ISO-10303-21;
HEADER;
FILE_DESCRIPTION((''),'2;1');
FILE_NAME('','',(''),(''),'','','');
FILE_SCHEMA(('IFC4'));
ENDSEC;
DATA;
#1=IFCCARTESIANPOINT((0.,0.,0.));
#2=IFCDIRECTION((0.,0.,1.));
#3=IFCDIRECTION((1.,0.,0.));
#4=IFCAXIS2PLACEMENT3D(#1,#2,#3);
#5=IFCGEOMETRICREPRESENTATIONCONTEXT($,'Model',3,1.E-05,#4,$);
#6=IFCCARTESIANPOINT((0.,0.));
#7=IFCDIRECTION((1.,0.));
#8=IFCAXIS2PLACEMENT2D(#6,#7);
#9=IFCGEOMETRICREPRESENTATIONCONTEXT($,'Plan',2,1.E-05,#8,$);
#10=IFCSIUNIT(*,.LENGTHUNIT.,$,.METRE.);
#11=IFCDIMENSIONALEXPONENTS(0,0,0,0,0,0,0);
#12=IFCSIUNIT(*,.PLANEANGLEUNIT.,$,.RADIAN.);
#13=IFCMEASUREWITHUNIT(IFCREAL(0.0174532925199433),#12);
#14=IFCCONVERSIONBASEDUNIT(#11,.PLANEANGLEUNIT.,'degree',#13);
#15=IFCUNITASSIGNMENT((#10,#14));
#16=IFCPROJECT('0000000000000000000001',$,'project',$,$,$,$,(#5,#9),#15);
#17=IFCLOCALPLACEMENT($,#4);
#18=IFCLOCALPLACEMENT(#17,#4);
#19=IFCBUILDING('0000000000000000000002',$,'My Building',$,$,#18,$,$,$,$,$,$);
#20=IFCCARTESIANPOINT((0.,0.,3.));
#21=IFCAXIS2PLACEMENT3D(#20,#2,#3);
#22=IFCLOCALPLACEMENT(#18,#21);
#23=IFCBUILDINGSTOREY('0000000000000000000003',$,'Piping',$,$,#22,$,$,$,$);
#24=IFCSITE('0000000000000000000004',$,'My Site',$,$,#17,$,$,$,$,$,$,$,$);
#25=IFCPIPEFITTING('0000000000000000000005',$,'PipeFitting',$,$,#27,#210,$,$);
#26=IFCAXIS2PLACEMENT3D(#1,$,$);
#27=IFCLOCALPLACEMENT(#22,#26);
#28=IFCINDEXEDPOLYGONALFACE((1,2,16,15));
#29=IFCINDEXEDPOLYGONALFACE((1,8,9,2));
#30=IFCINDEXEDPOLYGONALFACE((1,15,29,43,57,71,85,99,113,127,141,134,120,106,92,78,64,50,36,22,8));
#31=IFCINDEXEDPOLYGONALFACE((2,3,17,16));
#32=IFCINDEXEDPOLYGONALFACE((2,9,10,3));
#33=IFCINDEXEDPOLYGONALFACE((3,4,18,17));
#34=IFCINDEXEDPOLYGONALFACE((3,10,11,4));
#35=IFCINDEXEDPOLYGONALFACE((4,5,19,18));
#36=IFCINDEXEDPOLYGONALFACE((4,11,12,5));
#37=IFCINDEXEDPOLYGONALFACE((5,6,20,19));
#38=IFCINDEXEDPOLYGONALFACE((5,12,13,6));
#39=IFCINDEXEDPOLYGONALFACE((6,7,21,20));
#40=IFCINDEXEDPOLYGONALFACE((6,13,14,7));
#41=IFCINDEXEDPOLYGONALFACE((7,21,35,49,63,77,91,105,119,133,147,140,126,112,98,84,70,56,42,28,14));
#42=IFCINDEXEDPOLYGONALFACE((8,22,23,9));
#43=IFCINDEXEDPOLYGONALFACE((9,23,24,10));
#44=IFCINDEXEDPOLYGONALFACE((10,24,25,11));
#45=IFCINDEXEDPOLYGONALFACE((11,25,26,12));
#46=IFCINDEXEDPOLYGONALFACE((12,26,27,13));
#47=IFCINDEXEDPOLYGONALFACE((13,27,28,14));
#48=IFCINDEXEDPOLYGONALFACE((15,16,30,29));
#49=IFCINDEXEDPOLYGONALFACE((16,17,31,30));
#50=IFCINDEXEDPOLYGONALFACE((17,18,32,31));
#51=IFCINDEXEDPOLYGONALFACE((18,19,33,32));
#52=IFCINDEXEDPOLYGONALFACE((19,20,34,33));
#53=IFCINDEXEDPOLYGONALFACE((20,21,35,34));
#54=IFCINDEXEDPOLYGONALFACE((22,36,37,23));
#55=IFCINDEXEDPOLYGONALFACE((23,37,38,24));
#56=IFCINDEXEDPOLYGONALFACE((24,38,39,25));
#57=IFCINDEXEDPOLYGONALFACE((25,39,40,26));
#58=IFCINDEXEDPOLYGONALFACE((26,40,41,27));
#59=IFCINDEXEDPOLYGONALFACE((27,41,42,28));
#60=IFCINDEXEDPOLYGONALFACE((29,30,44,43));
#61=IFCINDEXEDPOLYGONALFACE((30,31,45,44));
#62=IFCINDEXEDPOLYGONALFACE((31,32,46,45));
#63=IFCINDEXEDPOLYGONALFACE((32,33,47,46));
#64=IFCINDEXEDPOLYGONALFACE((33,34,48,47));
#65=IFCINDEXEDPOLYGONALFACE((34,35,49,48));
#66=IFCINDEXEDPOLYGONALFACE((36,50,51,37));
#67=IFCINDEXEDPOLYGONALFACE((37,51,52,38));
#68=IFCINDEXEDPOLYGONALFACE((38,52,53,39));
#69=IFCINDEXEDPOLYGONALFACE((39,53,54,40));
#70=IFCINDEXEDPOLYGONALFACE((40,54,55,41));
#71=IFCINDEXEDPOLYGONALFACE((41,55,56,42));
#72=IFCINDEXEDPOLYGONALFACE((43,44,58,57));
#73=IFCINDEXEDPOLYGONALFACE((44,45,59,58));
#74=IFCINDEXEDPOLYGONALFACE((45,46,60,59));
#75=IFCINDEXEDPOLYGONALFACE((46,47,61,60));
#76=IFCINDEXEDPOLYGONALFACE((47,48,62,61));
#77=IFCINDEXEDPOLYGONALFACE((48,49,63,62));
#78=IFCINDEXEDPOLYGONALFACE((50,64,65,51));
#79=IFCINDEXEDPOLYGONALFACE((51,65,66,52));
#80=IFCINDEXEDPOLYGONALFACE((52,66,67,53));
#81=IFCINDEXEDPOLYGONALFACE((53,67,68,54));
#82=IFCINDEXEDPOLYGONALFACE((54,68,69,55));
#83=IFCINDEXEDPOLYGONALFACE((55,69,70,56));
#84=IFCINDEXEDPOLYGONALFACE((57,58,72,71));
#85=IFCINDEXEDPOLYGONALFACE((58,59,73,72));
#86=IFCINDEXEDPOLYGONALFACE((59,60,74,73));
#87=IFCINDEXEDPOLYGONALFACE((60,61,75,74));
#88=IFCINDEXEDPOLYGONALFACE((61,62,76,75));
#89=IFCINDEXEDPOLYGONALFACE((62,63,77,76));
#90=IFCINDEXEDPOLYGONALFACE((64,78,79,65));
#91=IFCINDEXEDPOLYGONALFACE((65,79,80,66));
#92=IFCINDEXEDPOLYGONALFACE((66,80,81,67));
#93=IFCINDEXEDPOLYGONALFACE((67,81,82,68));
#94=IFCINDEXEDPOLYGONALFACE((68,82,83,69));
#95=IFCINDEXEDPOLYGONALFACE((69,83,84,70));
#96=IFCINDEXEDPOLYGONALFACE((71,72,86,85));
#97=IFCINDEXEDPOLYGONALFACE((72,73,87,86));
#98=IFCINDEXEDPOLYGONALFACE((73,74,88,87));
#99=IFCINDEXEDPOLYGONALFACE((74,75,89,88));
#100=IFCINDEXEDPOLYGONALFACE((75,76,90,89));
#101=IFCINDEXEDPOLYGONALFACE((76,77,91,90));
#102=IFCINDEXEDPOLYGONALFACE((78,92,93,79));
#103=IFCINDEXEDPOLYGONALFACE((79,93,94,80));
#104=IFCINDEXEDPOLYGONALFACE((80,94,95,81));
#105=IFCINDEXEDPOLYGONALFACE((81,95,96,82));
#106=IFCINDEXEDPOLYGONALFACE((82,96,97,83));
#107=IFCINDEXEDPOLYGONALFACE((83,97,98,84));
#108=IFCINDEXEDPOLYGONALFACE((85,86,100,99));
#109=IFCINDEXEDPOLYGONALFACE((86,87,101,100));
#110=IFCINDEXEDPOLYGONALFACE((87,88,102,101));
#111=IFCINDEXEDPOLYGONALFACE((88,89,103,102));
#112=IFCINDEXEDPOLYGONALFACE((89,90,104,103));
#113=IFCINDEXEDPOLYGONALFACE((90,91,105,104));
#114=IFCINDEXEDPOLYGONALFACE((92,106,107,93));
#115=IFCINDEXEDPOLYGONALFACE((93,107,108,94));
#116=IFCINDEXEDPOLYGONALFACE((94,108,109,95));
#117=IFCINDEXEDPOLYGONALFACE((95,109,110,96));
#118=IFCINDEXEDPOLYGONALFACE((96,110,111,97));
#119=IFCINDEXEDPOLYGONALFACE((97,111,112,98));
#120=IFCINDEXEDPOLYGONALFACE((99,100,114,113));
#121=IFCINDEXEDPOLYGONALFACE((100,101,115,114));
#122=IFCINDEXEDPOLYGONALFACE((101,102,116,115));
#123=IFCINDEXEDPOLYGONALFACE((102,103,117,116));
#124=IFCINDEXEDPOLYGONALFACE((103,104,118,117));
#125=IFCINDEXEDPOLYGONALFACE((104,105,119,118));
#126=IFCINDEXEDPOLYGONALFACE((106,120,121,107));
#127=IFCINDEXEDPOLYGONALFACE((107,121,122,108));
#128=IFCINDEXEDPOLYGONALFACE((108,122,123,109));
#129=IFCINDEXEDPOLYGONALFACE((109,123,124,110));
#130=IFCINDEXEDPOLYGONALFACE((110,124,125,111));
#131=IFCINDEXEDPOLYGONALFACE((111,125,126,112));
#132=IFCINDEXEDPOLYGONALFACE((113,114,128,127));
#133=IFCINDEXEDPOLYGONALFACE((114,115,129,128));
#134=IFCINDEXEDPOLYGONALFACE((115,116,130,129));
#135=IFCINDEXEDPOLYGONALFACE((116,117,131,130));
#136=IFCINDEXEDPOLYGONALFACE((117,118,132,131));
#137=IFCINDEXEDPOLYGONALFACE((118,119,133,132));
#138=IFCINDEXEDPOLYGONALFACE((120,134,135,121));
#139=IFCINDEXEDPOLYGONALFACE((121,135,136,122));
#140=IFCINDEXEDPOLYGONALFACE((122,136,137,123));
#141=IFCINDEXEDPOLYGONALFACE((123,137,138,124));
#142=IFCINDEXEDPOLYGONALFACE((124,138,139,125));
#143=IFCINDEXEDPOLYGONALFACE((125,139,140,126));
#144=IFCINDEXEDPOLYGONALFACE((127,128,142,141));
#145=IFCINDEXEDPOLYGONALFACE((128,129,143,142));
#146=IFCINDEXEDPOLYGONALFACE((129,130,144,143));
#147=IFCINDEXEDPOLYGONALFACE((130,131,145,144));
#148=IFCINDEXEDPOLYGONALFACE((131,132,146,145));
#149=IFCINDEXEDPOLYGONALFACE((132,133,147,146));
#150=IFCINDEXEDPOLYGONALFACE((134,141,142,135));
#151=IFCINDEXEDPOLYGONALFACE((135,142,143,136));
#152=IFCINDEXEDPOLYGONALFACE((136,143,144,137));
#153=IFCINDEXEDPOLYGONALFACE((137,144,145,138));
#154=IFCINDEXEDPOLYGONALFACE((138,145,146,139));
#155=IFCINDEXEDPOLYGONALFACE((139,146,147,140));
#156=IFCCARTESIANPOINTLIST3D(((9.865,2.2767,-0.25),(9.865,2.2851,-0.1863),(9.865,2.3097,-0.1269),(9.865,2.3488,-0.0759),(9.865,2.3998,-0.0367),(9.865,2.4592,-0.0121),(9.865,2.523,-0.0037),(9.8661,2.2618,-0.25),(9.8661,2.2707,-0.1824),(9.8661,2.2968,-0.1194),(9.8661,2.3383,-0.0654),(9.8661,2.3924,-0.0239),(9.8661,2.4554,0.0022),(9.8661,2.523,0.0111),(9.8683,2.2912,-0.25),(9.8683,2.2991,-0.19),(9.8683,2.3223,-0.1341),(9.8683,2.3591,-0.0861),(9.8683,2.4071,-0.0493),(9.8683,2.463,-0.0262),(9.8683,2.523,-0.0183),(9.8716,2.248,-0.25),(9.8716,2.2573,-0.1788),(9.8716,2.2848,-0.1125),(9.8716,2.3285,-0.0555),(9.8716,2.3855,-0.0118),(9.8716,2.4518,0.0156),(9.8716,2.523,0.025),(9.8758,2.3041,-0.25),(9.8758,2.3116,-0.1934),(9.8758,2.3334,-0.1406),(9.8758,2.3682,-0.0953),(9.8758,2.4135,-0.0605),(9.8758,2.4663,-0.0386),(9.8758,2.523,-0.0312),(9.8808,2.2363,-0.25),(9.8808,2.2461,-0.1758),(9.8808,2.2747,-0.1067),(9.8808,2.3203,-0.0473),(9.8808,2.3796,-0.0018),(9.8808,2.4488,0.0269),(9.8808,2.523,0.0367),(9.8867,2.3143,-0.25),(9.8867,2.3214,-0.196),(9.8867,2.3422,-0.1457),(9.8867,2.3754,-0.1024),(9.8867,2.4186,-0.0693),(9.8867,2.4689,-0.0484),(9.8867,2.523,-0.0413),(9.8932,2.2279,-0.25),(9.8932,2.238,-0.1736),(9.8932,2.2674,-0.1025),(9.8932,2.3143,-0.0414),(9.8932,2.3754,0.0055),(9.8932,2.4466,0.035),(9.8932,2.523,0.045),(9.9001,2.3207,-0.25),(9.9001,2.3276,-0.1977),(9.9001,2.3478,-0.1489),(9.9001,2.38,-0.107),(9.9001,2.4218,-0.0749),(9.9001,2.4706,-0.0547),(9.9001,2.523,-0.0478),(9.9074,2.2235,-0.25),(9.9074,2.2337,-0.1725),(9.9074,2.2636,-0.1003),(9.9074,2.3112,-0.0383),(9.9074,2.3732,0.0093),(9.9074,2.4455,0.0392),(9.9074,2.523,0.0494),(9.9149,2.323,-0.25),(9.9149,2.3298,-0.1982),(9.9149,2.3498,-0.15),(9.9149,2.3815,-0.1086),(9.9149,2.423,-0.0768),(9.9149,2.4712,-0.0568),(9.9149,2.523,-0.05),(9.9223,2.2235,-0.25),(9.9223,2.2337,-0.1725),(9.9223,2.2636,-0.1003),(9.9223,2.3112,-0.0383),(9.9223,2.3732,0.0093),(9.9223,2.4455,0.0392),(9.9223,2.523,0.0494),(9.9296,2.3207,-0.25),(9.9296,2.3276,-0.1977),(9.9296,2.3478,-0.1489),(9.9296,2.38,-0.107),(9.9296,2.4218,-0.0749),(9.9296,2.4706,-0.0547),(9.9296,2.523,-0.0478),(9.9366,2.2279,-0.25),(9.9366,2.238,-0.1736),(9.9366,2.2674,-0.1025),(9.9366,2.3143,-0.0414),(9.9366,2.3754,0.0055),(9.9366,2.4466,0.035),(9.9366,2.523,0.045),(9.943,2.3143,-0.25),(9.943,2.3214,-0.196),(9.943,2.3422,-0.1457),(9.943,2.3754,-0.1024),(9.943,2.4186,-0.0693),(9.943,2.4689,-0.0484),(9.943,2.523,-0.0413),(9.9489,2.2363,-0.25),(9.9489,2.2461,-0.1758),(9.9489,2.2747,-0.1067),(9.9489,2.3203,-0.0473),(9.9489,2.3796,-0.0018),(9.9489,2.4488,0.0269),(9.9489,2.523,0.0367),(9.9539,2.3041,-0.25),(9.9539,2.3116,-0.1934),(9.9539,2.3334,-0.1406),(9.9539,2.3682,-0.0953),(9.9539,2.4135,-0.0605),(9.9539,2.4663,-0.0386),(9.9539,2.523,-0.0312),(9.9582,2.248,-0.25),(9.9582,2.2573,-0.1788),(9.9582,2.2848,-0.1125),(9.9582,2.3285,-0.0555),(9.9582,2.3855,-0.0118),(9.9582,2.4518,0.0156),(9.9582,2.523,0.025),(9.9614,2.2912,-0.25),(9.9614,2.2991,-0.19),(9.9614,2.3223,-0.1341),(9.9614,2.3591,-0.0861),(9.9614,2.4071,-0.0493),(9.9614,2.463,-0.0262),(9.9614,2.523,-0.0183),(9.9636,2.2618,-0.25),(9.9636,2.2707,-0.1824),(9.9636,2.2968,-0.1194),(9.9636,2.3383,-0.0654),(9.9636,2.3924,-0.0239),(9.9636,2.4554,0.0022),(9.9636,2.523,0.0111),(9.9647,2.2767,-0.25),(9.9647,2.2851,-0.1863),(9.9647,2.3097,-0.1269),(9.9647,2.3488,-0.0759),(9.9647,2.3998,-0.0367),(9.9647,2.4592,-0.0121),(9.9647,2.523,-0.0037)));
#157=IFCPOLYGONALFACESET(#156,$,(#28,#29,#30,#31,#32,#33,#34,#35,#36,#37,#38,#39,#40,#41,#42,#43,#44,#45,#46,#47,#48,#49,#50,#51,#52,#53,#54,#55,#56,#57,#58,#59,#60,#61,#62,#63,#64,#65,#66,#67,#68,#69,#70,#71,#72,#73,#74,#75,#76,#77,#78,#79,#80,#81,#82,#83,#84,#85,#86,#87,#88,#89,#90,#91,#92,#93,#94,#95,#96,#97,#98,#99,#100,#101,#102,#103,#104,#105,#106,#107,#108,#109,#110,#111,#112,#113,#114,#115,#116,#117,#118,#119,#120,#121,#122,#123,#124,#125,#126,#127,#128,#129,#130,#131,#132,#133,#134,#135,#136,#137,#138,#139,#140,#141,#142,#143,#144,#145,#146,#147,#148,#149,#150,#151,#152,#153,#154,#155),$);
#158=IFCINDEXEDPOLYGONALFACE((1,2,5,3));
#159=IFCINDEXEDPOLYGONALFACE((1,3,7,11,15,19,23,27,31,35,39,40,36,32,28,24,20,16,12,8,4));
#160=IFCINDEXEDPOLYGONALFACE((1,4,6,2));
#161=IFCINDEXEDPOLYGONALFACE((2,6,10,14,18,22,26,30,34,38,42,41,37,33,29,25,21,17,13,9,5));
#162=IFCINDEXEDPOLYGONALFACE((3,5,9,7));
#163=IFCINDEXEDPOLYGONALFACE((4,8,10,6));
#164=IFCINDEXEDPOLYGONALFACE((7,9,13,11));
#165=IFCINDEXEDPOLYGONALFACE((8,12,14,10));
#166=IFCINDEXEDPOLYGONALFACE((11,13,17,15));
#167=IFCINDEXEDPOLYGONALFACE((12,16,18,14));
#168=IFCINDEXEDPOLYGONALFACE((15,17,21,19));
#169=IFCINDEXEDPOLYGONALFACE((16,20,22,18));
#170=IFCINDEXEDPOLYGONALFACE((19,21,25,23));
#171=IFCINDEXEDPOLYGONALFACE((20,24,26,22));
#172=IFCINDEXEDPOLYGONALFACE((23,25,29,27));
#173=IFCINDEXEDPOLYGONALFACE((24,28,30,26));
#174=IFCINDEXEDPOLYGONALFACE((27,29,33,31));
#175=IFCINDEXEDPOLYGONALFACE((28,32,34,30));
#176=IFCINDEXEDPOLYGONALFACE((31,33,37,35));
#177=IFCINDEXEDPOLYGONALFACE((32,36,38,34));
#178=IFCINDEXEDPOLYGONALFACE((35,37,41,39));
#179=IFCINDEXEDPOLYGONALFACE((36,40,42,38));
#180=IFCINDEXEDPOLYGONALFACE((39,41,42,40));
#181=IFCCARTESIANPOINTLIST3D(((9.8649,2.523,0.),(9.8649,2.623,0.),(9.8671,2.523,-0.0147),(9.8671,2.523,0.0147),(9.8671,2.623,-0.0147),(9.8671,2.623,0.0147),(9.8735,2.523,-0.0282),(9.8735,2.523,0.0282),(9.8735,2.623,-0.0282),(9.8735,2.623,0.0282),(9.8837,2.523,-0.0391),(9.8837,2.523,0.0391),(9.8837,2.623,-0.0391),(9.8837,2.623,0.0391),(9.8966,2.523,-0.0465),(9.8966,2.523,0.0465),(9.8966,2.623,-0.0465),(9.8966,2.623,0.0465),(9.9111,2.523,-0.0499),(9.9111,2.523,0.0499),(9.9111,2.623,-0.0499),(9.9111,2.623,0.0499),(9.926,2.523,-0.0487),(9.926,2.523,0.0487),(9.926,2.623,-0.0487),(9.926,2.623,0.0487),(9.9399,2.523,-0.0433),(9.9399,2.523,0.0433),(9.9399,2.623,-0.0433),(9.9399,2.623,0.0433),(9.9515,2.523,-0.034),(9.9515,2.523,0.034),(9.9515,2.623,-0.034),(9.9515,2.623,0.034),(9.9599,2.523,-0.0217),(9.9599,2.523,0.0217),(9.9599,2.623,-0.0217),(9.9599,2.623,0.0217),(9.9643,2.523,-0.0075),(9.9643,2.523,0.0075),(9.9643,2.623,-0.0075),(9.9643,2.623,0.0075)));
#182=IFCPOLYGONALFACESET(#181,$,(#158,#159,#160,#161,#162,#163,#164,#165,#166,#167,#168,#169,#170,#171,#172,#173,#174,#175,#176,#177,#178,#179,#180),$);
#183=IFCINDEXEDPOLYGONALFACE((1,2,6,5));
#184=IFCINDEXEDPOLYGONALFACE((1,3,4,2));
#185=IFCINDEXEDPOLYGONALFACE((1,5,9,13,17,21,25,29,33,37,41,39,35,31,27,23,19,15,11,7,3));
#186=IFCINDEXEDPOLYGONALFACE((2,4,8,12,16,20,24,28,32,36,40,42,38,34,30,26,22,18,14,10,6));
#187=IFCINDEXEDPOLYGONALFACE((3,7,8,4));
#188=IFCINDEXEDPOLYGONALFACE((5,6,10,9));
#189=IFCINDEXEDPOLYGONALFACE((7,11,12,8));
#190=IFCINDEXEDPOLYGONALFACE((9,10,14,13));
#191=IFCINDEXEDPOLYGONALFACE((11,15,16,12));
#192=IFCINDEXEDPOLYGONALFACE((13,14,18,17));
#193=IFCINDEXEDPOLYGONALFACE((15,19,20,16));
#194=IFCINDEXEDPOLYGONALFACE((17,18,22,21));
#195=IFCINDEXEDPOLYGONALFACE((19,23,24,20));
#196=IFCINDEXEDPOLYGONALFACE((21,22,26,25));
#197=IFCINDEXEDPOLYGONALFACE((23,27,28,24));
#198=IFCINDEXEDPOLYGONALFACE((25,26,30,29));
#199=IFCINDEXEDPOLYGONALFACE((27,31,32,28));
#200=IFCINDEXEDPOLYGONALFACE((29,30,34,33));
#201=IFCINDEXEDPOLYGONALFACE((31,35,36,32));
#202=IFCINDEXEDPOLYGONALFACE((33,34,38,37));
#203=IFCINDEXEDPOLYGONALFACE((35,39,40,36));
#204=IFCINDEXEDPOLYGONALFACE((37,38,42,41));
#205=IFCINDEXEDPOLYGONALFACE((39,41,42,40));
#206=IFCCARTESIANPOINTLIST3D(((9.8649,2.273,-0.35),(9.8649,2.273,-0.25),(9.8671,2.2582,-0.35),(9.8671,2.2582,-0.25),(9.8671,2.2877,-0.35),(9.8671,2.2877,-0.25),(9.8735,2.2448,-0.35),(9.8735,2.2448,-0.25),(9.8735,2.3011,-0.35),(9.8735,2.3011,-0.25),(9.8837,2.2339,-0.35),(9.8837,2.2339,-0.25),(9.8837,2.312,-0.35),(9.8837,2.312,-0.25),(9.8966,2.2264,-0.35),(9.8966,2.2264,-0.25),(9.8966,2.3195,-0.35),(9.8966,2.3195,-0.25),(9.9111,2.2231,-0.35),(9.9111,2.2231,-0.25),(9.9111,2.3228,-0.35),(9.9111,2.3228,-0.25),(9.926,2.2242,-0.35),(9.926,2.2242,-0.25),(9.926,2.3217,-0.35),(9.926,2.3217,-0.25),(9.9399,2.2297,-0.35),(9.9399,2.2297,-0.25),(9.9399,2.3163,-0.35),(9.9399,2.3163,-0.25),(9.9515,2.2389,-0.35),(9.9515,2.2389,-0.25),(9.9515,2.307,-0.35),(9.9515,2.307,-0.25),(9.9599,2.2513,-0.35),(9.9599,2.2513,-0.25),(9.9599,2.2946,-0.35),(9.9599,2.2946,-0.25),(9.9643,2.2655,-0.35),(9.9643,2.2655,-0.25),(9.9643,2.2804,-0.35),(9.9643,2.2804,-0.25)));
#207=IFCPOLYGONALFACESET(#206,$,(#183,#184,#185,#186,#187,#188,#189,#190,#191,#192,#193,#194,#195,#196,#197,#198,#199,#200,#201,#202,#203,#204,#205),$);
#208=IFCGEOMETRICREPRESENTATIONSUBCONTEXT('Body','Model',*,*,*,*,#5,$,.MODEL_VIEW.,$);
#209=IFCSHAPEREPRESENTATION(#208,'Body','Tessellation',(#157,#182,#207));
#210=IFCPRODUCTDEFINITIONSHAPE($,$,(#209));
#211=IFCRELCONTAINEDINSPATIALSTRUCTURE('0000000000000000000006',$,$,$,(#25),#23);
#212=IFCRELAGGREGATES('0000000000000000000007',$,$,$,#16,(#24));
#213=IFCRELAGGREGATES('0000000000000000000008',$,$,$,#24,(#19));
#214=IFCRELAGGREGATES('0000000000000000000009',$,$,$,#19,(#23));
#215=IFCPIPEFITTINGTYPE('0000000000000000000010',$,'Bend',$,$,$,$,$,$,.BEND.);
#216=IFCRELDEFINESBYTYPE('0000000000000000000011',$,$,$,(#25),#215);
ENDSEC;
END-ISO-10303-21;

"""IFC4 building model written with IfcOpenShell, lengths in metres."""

from ifc_helpers import new_model, entity, si_unit, converted_unit, frame, origin_with_axes, origin_2d_with_axis, place, context, subcontext, project, spatial, circle, extrude, source, transform, mapped, type_object, type_shapes, element, save


model = new_model("IFC4")

# Units and contexts
model_context = context("Model", 3, precision=1e-05, world=origin_with_axes())
plan_context = context("Plan", 2, precision=1e-05, world=origin_2d_with_axis())
body_context = subcontext(model_context, "Body", "Model", "MODEL_VIEW")
ifc_project = project(units=[si_unit("LENGTHUNIT", "METRE"), converted_unit("PLANEANGLEUNIT", "degree", entity("IfcReal", 0.0174532925199433), si_unit("PLANEANGLEUNIT", "RADIAN"), dimensions=[0, 0, 0, 0, 0, 0, 0])], contexts=[model_context, plan_context])

# Site, building, storey
site_placement = place(None, origin_with_axes())
site = spatial("IfcSite", under=ifc_project, at=site_placement, Name="My Site")
building_placement = place(site_placement, origin_with_axes())
building = spatial("IfcBuilding", under=site, at=building_placement, Name="My Building")
storey_placement = place(building_placement, frame((0.0, 0.0, 3.0), z_axis=(0.0, 0.0, 1.0), x_axis=(1.0, 0.0, 0.0)))
storey = spatial("IfcBuildingStorey", under=building, at=storey_placement, Name="Piping")

# Pipe fitting
pipe_fitting_type = type_object("IfcPipeFittingType", Name="Bend", PredefinedType="BEND")
shared_shape = source(origin_with_axes(), body_context, "Body", "SolidModel", [
    entity("IfcSweptDiskSolid", entity("IfcIndexedPolyCurve", entity("IfcCartesianPointList3D", [[0.0, 0.0, -0.1], [0.0, -0.0732, -0.2768], [0.0, -0.25, -0.35]]), [entity("IfcArcIndex", [1, 2, 3])]), 0.05),
    extrude(circle(Radius=0.05), origin_with_axes(), (0.0, 0.0, -1.0), 0.1),
    extrude(circle(Radius=0.05), frame((0.0, -0.25, -0.35), z_axis=(0.0, -1.0, 0.0), x_axis=(1.0, 0.0, 0.0)), (0.0, 0.0, 1.0), 0.1),
])
type_shapes(pipe_fitting_type, [shared_shape])
for number, where, z_axis, x_axis, name in (
    (1, (9.9149, 2.623, 0.0), (0.0, 1.0, 0.0), (-1.0, 0.0, 0.0), "PipeFitting"),
):
    element("IfcPipeFitting", number, at=place(storey_placement, frame(where, z_axis=z_axis, x_axis=x_axis)), inside=storey, type_object=pipe_fitting_type, Name=name, context=body_context, shape_type="MappedRepresentation", body=[
        mapped(shared_shape, transform((0.0, 0.0, 0.0), x_axis=(1.0, 0.0, 0.0), y_axis=(0.0, 1.0, 0.0), z_axis=(0.0, 0.0, 1.0), scale=1.0)),
    ])

save(model, "model.ifc")
